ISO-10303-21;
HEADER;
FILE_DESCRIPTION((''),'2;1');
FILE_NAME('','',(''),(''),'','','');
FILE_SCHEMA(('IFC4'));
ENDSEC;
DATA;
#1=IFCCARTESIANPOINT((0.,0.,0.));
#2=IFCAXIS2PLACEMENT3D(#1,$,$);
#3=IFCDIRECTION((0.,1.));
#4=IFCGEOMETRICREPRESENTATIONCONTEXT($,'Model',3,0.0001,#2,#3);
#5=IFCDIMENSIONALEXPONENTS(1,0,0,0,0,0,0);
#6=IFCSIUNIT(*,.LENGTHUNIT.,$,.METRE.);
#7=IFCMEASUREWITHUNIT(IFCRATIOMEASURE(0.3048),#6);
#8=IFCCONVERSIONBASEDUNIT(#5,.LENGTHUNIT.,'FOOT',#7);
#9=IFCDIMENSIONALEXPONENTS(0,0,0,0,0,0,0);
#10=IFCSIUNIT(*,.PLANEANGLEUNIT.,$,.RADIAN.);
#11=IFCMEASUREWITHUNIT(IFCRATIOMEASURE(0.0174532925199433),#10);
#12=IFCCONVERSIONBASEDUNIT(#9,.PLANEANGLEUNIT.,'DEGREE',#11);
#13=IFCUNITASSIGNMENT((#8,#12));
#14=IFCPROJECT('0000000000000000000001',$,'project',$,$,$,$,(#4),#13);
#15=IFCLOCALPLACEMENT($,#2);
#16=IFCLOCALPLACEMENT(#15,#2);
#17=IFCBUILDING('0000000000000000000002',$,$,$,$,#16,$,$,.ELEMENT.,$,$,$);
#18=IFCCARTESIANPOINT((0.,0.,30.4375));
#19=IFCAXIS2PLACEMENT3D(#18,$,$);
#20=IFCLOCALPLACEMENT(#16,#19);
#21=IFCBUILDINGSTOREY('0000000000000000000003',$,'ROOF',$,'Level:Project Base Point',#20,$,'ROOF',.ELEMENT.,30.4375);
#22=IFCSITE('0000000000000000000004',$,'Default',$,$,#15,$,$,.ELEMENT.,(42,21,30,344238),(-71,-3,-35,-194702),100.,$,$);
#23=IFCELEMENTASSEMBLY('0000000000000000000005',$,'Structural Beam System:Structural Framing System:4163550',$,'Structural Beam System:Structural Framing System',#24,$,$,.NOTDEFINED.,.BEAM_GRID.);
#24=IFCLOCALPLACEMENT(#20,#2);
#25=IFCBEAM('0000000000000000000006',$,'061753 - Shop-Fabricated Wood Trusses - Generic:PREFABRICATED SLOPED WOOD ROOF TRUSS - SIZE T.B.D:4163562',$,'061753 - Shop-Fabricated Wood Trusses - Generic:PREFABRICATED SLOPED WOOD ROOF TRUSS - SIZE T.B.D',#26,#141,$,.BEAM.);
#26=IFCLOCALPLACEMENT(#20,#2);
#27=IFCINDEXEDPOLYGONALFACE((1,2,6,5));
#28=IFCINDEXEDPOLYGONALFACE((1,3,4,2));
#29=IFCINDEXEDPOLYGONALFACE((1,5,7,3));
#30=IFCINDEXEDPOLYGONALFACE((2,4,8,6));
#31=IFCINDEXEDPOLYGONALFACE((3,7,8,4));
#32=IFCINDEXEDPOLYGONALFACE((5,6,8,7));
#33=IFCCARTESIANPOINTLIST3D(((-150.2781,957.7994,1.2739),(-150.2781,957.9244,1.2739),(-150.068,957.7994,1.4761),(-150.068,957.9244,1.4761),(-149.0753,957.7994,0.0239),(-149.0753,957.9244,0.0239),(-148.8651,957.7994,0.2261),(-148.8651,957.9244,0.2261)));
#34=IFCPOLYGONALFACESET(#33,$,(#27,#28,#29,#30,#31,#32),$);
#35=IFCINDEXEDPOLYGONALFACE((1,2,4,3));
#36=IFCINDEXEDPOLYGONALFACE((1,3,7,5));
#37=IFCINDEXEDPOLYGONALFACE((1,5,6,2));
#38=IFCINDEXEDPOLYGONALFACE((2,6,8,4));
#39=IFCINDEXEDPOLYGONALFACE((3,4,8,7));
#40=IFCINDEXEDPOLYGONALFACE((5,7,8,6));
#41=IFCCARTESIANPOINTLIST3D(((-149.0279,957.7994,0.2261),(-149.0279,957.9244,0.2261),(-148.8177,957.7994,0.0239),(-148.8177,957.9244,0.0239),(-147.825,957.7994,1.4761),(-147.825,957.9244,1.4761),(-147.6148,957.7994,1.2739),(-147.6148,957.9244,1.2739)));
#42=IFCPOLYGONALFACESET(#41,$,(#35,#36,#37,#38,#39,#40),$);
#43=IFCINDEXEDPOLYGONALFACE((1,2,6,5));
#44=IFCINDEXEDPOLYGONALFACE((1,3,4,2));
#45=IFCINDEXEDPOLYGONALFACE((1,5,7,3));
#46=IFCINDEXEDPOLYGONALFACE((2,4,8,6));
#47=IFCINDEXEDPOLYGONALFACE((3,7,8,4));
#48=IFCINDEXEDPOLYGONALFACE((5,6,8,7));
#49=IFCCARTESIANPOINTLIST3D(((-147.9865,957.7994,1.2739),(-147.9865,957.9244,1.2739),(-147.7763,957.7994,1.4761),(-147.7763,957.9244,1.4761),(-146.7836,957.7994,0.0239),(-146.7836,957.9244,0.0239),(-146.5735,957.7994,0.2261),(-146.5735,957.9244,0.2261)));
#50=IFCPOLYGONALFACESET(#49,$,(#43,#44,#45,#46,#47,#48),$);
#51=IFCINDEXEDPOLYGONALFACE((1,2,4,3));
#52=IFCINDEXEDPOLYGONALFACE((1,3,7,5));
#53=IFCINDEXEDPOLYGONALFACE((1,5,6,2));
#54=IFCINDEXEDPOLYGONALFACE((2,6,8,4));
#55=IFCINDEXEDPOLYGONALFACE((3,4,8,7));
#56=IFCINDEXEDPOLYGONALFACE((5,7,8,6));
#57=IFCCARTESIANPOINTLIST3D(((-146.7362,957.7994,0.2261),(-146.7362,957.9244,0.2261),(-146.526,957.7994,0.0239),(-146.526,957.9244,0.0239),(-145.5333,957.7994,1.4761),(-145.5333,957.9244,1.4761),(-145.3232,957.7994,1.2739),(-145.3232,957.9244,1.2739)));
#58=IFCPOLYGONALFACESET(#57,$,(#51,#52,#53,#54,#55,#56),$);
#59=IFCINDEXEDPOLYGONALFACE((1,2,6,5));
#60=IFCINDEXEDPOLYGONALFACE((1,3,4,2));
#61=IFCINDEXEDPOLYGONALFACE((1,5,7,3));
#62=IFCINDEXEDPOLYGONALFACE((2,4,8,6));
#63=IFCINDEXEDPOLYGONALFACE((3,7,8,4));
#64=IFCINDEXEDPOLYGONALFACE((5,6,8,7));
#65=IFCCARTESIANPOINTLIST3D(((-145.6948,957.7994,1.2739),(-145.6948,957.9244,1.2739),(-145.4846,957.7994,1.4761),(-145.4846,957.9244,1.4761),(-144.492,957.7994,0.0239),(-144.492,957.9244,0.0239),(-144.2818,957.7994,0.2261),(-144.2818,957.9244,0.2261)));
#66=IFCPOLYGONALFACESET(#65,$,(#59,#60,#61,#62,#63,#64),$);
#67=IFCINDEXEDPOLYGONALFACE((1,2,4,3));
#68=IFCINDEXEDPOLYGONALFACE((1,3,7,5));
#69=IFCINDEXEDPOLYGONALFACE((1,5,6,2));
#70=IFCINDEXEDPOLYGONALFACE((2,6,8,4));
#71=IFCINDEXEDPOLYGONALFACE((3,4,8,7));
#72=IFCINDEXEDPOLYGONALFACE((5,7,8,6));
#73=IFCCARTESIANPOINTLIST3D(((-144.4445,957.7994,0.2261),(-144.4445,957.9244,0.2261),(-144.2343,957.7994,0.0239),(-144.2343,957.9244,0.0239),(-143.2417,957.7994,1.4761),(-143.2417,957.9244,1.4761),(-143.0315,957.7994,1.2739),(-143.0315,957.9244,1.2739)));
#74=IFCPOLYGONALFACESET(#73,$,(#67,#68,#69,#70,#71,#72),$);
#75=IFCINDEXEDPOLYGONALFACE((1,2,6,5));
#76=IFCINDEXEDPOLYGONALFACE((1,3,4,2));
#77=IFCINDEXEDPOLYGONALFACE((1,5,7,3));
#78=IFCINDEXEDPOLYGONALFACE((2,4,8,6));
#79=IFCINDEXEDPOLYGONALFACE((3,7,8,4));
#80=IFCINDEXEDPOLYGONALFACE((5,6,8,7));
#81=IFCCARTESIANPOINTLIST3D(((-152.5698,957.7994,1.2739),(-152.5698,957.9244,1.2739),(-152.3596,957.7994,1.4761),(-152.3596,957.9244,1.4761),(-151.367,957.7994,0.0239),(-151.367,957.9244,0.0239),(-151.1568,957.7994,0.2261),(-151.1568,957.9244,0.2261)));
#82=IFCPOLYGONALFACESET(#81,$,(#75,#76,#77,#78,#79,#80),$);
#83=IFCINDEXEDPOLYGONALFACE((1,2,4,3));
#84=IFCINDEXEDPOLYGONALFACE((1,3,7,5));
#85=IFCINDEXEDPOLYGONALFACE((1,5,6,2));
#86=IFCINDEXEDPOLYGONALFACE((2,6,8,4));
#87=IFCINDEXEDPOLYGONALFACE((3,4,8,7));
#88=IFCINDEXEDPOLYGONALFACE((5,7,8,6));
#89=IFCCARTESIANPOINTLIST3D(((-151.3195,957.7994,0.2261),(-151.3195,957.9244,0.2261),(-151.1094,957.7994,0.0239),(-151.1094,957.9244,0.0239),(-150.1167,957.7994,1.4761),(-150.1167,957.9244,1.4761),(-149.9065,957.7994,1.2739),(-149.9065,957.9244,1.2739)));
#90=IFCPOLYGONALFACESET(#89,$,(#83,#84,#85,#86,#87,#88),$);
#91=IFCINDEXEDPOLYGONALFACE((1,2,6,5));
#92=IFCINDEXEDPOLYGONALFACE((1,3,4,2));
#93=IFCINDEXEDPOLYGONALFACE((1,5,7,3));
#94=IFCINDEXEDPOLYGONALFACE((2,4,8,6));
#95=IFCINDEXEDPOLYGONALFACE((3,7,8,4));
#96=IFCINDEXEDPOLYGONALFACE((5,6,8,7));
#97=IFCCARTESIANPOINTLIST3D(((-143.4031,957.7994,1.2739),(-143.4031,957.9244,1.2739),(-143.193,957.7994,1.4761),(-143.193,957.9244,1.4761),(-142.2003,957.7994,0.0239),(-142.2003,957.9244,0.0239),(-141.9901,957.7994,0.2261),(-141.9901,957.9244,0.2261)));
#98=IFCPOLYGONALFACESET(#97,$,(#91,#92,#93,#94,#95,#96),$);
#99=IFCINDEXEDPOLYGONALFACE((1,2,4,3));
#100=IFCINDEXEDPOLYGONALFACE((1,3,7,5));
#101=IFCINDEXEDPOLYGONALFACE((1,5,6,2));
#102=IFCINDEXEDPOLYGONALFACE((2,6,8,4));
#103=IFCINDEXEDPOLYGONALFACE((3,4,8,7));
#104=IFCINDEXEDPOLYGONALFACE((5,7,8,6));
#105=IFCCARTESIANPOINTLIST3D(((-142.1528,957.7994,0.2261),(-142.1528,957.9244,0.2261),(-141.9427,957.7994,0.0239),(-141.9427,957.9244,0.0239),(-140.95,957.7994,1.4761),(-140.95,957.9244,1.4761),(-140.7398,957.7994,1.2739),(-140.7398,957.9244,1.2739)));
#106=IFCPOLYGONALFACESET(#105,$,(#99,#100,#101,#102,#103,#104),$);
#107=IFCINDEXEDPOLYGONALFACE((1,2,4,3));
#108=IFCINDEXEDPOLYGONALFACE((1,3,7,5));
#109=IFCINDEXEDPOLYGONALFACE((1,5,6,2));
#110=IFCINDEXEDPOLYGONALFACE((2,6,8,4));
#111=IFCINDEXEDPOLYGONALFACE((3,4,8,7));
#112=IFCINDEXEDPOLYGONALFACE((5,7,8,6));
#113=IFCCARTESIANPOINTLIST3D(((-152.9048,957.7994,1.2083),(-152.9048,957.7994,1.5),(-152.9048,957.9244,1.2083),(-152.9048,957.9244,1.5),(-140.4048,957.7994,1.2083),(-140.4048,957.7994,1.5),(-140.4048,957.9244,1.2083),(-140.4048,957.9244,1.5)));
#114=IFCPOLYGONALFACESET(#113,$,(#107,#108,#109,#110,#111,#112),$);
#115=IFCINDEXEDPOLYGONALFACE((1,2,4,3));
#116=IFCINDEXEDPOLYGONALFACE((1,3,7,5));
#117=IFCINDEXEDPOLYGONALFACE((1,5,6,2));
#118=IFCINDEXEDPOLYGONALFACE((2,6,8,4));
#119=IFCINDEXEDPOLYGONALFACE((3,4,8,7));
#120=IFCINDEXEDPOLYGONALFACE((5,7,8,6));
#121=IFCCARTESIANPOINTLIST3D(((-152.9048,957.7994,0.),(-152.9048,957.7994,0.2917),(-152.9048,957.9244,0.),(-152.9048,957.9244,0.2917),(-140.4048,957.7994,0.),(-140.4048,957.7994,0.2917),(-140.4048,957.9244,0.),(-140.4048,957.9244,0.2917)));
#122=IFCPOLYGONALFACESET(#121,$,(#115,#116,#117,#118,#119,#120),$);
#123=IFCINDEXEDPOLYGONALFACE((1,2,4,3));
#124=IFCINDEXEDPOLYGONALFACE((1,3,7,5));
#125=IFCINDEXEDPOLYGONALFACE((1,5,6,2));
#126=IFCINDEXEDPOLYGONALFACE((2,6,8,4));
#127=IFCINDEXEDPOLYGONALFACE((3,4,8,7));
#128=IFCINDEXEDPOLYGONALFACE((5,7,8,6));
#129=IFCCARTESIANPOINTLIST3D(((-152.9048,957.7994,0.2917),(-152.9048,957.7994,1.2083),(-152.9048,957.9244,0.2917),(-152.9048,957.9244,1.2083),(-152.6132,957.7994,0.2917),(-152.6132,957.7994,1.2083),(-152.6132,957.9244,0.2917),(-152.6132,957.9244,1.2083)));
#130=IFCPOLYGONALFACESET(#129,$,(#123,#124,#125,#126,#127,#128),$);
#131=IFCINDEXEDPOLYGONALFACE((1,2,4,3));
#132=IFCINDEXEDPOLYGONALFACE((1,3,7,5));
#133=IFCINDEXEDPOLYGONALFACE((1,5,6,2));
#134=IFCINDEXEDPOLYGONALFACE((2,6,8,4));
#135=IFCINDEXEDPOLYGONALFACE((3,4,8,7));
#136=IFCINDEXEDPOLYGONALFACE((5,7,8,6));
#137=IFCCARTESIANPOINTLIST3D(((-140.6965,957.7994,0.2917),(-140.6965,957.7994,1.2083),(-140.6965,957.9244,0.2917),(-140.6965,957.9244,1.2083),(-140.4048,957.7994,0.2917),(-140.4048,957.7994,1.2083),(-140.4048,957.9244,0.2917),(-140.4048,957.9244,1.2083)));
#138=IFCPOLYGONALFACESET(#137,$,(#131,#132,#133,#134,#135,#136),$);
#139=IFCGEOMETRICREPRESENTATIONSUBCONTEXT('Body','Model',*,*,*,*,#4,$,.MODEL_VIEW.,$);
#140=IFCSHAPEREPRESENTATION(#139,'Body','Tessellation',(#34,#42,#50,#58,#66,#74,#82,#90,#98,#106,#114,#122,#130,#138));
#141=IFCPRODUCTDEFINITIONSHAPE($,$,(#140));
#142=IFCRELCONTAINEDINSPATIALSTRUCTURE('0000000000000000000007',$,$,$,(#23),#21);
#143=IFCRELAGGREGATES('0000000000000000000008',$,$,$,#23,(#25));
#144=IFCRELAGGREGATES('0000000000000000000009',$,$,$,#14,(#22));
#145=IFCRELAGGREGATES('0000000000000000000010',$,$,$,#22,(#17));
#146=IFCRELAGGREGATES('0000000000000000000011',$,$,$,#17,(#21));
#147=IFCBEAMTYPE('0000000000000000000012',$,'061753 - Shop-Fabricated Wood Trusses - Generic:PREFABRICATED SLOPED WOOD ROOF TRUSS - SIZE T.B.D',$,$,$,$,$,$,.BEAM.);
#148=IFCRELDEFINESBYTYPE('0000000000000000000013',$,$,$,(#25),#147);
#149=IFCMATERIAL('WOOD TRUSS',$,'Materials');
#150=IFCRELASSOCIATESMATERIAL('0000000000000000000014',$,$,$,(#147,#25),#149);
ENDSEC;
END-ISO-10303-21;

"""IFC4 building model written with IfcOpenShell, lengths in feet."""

from ifc_helpers import new_model, entity, si_unit, converted_unit, direction, frame, frame_2d, origin, origin_2d_with_axis, place, context, subcontext, project, spatial, rectangle, extrude, source, transform, mapped, material, material_profile, profile_set, profile_usage, type_object, type_shapes, element, aggregate, save


model = new_model("IFC4")

# Units and contexts
model_context = context("Model", 3, precision=0.0001, world=origin(), true_north=direction((0.0, 1.0)))
body_context = subcontext(model_context, "Body", "Model", "MODEL_VIEW")
ifc_project = project(units=[converted_unit("LENGTHUNIT", "FOOT", entity("IfcRatioMeasure", 0.3048), si_unit("LENGTHUNIT", "METRE"), dimensions=[1, 0, 0, 0, 0, 0, 0]), converted_unit("PLANEANGLEUNIT", "DEGREE", entity("IfcRatioMeasure", 0.0174532925199433), si_unit("PLANEANGLEUNIT", "RADIAN"), dimensions=[0, 0, 0, 0, 0, 0, 0])], contexts=[model_context])

# Site, building, storey
site_placement = place(None, origin())
site = spatial("IfcSite", under=ifc_project, at=site_placement, Name="Default", CompositionType="ELEMENT", RefLatitude=(42, 21, 30, 344238), RefLongitude=(-71, -3, -35, -194702), RefElevation=100.0)
building_placement = place(site_placement, origin())
building = spatial("IfcBuilding", under=site, at=building_placement, CompositionType="ELEMENT")
storey_placement = place(building_placement, frame((0.0, 0.0, 30.4375)))
storey = spatial("IfcBuildingStorey", under=building, at=storey_placement, Name="ROOF", ObjectType="Level:Project Base Point", LongName="ROOF", CompositionType="ELEMENT", Elevation=30.4375)

# Element assembly, beam
assembly_1_placement = place(storey_placement, origin())
assembly_1 = element("IfcElementAssembly", 1, at=assembly_1_placement, inside=storey, Name="Structural Beam System:Structural Framing System:4163550", ObjectType="Structural Beam System:Structural Framing System", AssemblyPlace="NOTDEFINED", PredefinedType="BEAM_GRID")
ifc_material_1 = material(Name="WOOD TRUSS", Category="Materials")
ifc_material_profile_1 = material_profile(ifc_material_1, rectangle(XDim=1.7347, YDim=0.125, at=origin_2d_with_axis()), Name="PREFABRICATED SLOPED WOOD ROOF TRUSS - SIZE T.B.D")
ifc_material_profile_2 = material_profile(ifc_material_1, rectangle(XDim=1.7347, YDim=0.125, at=frame_2d((0.0, 0.0), x_axis=(1.0, 0.0))), Name="PREFABRICATED SLOPED WOOD ROOF TRUSS - SIZE T.B.D")
ifc_material_profile_3 = material_profile(ifc_material_1, rectangle(XDim=1.7347, YDim=0.125, at=origin_2d_with_axis()), Name="PREFABRICATED SLOPED WOOD ROOF TRUSS - SIZE T.B.D")
ifc_material_profile_4 = material_profile(ifc_material_1, rectangle(XDim=1.7347, YDim=0.125, at=origin_2d_with_axis()), Name="PREFABRICATED SLOPED WOOD ROOF TRUSS - SIZE T.B.D")
ifc_material_profile_5 = material_profile(ifc_material_1, rectangle(XDim=1.7347, YDim=0.125, at=frame_2d((0.0, 0.0), x_axis=(1.0, 0.0))), Name="PREFABRICATED SLOPED WOOD ROOF TRUSS - SIZE T.B.D")
ifc_material_profile_6 = material_profile(ifc_material_1, rectangle(XDim=1.7347, YDim=0.125, at=frame_2d((0.0, 0.0), x_axis=(1.0, 0.0))), Name="PREFABRICATED SLOPED WOOD ROOF TRUSS - SIZE T.B.D")
ifc_material_profile_7 = material_profile(ifc_material_1, rectangle(XDim=1.7347, YDim=0.125, at=frame_2d((0.0, 0.0), x_axis=(1.0, 0.0))), Name="PREFABRICATED SLOPED WOOD ROOF TRUSS - SIZE T.B.D")
ifc_material_profile_8 = material_profile(ifc_material_1, rectangle(XDim=1.7347, YDim=0.125, at=frame_2d((0.0, 0.0), x_axis=(1.0, 0.0))), Name="PREFABRICATED SLOPED WOOD ROOF TRUSS - SIZE T.B.D")
ifc_material_profile_9 = material_profile(ifc_material_1, rectangle(XDim=1.7347, YDim=0.125, at=origin_2d_with_axis()), Name="PREFABRICATED SLOPED WOOD ROOF TRUSS - SIZE T.B.D")
ifc_material_profile_10 = material_profile(ifc_material_1, rectangle(XDim=1.7347, YDim=0.125, at=frame_2d((0.0, 0.0), x_axis=(1.0, 0.0))), Name="PREFABRICATED SLOPED WOOD ROOF TRUSS - SIZE T.B.D")
ifc_material_profile_11 = material_profile(ifc_material_1, rectangle(XDim=0.2917, YDim=0.125, at=frame_2d((0.0, 0.0), x_axis=(1.0, 0.0))), Name="PREFABRICATED SLOPED WOOD ROOF TRUSS - SIZE T.B.D")
ifc_material_profile_12 = material_profile(ifc_material_1, rectangle(XDim=0.2917, YDim=0.125, at=frame_2d((0.0, 0.0), x_axis=(1.0, 0.0))), Name="PREFABRICATED SLOPED WOOD ROOF TRUSS - SIZE T.B.D")
ifc_material_profile_13 = material_profile(ifc_material_1, rectangle(XDim=0.9167, YDim=0.125, at=frame_2d((0.0, 0.0), x_axis=(1.0, 0.0))), Name="PREFABRICATED SLOPED WOOD ROOF TRUSS - SIZE T.B.D")
ifc_material_profile_14 = material_profile(ifc_material_1, rectangle(XDim=0.9167, YDim=0.125, at=frame_2d((0.0, 0.0), x_axis=(1.0, 0.0))), Name="PREFABRICATED SLOPED WOOD ROOF TRUSS - SIZE T.B.D")
ifc_profile_set_1 = profile_set([ifc_material_profile_1, ifc_material_profile_2, ifc_material_profile_3, ifc_material_profile_4, ifc_material_profile_5, ifc_material_profile_6, ifc_material_profile_7, ifc_material_profile_8, ifc_material_profile_9, ifc_material_profile_10, ifc_material_profile_11, ifc_material_profile_12, ifc_material_profile_13, ifc_material_profile_14], Name="PREFABRICATED SLOPED WOOD ROOF TRUSS - SIZE T.B.D")
ifc_profile_usage_1 = profile_usage(ifc_profile_set_1, cardinal=8)
beam_type_1 = type_object("IfcBeamType", Name="061753 - Shop-Fabricated Wood Trusses - Generic:PREFABRICATED SLOPED WOOD ROOF TRUSS - SIZE T.B.D", PredefinedType="BEAM", material=ifc_profile_set_1)
shared_shape_1 = source(origin(), body_context, "Body", "SweptSolid", [
    extrude(rectangle(XDim=1.7347, YDim=0.125, at=origin_2d_with_axis()), frame((2.8117, 0.0, 0.1011), z_axis=(0.720569, 0.0, -0.693383), x_axis=(0.693383, 0.0, 0.720569)), (0.0, 0.0, 1.0), 0.2917),
    extrude(rectangle(XDim=1.7347, YDim=0.125, at=frame_2d((0.0, 0.0), x_axis=(1.0, 0.0))), frame((1.5614, 0.0, -0.1011), z_axis=(0.720569, 0.0, 0.693383), x_axis=(0.693383, 0.0, -0.720569)), (0.0, 0.0, 1.0), 0.2917),
    extrude(rectangle(XDim=1.7347, YDim=0.125, at=origin_2d_with_axis()), frame((0.5201, 0.0, 0.1011), z_axis=(0.720569, 0.0, -0.693383), x_axis=(0.693383, 0.0, 0.720569)), (0.0, 0.0, 1.0), 0.2917),
    extrude(rectangle(XDim=1.7347, YDim=0.125, at=origin_2d_with_axis()), frame((-0.7302, 0.0, -0.1011), z_axis=(0.720569, 0.0, 0.693383), x_axis=(0.693383, 0.0, -0.720569)), (0.0, 0.0, 1.0), 0.2917),
    extrude(rectangle(XDim=1.7347, YDim=0.125, at=frame_2d((0.0, 0.0), x_axis=(1.0, 0.0))), frame((-1.7716, 0.0, 0.1011), z_axis=(0.720569, 0.0, -0.693383), x_axis=(0.693383, 0.0, 0.720569)), (0.0, 0.0, 1.0), 0.2917),
    extrude(rectangle(XDim=1.7347, YDim=0.125, at=frame_2d((0.0, 0.0), x_axis=(1.0, 0.0))), frame((-3.0219, 0.0, -0.1011), z_axis=(0.720569, 0.0, 0.693383), x_axis=(0.693383, 0.0, -0.720569)), (0.0, 0.0, 1.0), 0.2917),
    extrude(rectangle(XDim=1.7347, YDim=0.125, at=frame_2d((0.0, 0.0), x_axis=(1.0, 0.0))), frame((5.1034, 0.0, 0.1011), z_axis=(0.720569, 0.0, -0.693383), x_axis=(0.693383, 0.0, 0.720569)), (0.0, 0.0, 1.0), 0.2917),
    extrude(rectangle(XDim=1.7347, YDim=0.125, at=frame_2d((0.0, 0.0), x_axis=(1.0, 0.0))), frame((3.8531, 0.0, -0.1011), z_axis=(0.720569, 0.0, 0.693383), x_axis=(0.693383, 0.0, -0.720569)), (0.0, 0.0, 1.0), 0.2917),
    extrude(rectangle(XDim=1.7347, YDim=0.125, at=origin_2d_with_axis()), frame((-4.0633, 0.0, 0.1011), z_axis=(0.720569, 0.0, -0.693383), x_axis=(0.693383, 0.0, 0.720569)), (0.0, 0.0, 1.0), 0.2917),
    extrude(rectangle(XDim=1.7347, YDim=0.125, at=frame_2d((0.0, 0.0), x_axis=(1.0, 0.0))), frame((-5.3136, 0.0, -0.1011), z_axis=(0.720569, 0.0, 0.693383), x_axis=(0.693383, 0.0, -0.720569)), (0.0, 0.0, 1.0), 0.2917),
    extrude(rectangle(XDim=0.2917, YDim=0.125, at=frame_2d((0.0, 0.0), x_axis=(1.0, 0.0))), frame((-6.25, 0.0, 0.6042), z_axis=(1.0, 0.0, 0.0), x_axis=(0.0, 0.0, -1.0)), (0.0, 0.0, 1.0), 12.5),
    extrude(rectangle(XDim=0.2917, YDim=0.125, at=frame_2d((0.0, 0.0), x_axis=(1.0, 0.0))), frame((-6.25, 0.0, -0.6042), z_axis=(1.0, 0.0, 0.0), x_axis=(0.0, 0.0, -1.0)), (0.0, 0.0, 1.0), 12.5),
    extrude(rectangle(XDim=0.9167, YDim=0.125, at=frame_2d((0.0, 0.0), x_axis=(1.0, 0.0))), frame((5.9583, 0.0, 0.0), z_axis=(1.0, 0.0, 0.0), x_axis=(0.0, 0.0, -1.0)), (0.0, 0.0, 1.0), 0.2917),
    extrude(rectangle(XDim=0.9167, YDim=0.125, at=frame_2d((0.0, 0.0), x_axis=(1.0, 0.0))), frame((-6.25, 0.0, 0.0), z_axis=(1.0, 0.0, 0.0), x_axis=(0.0, 0.0, -1.0)), (0.0, 0.0, 1.0), 0.2917),
])
type_shapes(beam_type_1, [shared_shape_1])
beam_1_placement = place(assembly_1_placement, frame((-146.6548, 957.8619, 0.75), z_axis=(0.0, 0.0, 1.0), x_axis=(-1.0, 0.0, 0.0)))
beam_1 = element("IfcBeam", 2, at=beam_1_placement, type_object=beam_type_1, material=ifc_profile_usage_1, Name="061753 - Shop-Fabricated Wood Trusses - Generic:PREFABRICATED SLOPED WOOD ROOF TRUSS - SIZE T.B.D:4163562", ObjectType="061753 - Shop-Fabricated Wood Trusses - Generic:PREFABRICATED SLOPED WOOD ROOF TRUSS - SIZE T.B.D", PredefinedType="BEAM", context=body_context, shape_type="MappedRepresentation", body=[
    mapped(shared_shape_1, transform((0.0, 0.0, 0.0), scale=1.0)),
])
aggregate(assembly_1, [beam_1])

save(model, "model.ifc")
